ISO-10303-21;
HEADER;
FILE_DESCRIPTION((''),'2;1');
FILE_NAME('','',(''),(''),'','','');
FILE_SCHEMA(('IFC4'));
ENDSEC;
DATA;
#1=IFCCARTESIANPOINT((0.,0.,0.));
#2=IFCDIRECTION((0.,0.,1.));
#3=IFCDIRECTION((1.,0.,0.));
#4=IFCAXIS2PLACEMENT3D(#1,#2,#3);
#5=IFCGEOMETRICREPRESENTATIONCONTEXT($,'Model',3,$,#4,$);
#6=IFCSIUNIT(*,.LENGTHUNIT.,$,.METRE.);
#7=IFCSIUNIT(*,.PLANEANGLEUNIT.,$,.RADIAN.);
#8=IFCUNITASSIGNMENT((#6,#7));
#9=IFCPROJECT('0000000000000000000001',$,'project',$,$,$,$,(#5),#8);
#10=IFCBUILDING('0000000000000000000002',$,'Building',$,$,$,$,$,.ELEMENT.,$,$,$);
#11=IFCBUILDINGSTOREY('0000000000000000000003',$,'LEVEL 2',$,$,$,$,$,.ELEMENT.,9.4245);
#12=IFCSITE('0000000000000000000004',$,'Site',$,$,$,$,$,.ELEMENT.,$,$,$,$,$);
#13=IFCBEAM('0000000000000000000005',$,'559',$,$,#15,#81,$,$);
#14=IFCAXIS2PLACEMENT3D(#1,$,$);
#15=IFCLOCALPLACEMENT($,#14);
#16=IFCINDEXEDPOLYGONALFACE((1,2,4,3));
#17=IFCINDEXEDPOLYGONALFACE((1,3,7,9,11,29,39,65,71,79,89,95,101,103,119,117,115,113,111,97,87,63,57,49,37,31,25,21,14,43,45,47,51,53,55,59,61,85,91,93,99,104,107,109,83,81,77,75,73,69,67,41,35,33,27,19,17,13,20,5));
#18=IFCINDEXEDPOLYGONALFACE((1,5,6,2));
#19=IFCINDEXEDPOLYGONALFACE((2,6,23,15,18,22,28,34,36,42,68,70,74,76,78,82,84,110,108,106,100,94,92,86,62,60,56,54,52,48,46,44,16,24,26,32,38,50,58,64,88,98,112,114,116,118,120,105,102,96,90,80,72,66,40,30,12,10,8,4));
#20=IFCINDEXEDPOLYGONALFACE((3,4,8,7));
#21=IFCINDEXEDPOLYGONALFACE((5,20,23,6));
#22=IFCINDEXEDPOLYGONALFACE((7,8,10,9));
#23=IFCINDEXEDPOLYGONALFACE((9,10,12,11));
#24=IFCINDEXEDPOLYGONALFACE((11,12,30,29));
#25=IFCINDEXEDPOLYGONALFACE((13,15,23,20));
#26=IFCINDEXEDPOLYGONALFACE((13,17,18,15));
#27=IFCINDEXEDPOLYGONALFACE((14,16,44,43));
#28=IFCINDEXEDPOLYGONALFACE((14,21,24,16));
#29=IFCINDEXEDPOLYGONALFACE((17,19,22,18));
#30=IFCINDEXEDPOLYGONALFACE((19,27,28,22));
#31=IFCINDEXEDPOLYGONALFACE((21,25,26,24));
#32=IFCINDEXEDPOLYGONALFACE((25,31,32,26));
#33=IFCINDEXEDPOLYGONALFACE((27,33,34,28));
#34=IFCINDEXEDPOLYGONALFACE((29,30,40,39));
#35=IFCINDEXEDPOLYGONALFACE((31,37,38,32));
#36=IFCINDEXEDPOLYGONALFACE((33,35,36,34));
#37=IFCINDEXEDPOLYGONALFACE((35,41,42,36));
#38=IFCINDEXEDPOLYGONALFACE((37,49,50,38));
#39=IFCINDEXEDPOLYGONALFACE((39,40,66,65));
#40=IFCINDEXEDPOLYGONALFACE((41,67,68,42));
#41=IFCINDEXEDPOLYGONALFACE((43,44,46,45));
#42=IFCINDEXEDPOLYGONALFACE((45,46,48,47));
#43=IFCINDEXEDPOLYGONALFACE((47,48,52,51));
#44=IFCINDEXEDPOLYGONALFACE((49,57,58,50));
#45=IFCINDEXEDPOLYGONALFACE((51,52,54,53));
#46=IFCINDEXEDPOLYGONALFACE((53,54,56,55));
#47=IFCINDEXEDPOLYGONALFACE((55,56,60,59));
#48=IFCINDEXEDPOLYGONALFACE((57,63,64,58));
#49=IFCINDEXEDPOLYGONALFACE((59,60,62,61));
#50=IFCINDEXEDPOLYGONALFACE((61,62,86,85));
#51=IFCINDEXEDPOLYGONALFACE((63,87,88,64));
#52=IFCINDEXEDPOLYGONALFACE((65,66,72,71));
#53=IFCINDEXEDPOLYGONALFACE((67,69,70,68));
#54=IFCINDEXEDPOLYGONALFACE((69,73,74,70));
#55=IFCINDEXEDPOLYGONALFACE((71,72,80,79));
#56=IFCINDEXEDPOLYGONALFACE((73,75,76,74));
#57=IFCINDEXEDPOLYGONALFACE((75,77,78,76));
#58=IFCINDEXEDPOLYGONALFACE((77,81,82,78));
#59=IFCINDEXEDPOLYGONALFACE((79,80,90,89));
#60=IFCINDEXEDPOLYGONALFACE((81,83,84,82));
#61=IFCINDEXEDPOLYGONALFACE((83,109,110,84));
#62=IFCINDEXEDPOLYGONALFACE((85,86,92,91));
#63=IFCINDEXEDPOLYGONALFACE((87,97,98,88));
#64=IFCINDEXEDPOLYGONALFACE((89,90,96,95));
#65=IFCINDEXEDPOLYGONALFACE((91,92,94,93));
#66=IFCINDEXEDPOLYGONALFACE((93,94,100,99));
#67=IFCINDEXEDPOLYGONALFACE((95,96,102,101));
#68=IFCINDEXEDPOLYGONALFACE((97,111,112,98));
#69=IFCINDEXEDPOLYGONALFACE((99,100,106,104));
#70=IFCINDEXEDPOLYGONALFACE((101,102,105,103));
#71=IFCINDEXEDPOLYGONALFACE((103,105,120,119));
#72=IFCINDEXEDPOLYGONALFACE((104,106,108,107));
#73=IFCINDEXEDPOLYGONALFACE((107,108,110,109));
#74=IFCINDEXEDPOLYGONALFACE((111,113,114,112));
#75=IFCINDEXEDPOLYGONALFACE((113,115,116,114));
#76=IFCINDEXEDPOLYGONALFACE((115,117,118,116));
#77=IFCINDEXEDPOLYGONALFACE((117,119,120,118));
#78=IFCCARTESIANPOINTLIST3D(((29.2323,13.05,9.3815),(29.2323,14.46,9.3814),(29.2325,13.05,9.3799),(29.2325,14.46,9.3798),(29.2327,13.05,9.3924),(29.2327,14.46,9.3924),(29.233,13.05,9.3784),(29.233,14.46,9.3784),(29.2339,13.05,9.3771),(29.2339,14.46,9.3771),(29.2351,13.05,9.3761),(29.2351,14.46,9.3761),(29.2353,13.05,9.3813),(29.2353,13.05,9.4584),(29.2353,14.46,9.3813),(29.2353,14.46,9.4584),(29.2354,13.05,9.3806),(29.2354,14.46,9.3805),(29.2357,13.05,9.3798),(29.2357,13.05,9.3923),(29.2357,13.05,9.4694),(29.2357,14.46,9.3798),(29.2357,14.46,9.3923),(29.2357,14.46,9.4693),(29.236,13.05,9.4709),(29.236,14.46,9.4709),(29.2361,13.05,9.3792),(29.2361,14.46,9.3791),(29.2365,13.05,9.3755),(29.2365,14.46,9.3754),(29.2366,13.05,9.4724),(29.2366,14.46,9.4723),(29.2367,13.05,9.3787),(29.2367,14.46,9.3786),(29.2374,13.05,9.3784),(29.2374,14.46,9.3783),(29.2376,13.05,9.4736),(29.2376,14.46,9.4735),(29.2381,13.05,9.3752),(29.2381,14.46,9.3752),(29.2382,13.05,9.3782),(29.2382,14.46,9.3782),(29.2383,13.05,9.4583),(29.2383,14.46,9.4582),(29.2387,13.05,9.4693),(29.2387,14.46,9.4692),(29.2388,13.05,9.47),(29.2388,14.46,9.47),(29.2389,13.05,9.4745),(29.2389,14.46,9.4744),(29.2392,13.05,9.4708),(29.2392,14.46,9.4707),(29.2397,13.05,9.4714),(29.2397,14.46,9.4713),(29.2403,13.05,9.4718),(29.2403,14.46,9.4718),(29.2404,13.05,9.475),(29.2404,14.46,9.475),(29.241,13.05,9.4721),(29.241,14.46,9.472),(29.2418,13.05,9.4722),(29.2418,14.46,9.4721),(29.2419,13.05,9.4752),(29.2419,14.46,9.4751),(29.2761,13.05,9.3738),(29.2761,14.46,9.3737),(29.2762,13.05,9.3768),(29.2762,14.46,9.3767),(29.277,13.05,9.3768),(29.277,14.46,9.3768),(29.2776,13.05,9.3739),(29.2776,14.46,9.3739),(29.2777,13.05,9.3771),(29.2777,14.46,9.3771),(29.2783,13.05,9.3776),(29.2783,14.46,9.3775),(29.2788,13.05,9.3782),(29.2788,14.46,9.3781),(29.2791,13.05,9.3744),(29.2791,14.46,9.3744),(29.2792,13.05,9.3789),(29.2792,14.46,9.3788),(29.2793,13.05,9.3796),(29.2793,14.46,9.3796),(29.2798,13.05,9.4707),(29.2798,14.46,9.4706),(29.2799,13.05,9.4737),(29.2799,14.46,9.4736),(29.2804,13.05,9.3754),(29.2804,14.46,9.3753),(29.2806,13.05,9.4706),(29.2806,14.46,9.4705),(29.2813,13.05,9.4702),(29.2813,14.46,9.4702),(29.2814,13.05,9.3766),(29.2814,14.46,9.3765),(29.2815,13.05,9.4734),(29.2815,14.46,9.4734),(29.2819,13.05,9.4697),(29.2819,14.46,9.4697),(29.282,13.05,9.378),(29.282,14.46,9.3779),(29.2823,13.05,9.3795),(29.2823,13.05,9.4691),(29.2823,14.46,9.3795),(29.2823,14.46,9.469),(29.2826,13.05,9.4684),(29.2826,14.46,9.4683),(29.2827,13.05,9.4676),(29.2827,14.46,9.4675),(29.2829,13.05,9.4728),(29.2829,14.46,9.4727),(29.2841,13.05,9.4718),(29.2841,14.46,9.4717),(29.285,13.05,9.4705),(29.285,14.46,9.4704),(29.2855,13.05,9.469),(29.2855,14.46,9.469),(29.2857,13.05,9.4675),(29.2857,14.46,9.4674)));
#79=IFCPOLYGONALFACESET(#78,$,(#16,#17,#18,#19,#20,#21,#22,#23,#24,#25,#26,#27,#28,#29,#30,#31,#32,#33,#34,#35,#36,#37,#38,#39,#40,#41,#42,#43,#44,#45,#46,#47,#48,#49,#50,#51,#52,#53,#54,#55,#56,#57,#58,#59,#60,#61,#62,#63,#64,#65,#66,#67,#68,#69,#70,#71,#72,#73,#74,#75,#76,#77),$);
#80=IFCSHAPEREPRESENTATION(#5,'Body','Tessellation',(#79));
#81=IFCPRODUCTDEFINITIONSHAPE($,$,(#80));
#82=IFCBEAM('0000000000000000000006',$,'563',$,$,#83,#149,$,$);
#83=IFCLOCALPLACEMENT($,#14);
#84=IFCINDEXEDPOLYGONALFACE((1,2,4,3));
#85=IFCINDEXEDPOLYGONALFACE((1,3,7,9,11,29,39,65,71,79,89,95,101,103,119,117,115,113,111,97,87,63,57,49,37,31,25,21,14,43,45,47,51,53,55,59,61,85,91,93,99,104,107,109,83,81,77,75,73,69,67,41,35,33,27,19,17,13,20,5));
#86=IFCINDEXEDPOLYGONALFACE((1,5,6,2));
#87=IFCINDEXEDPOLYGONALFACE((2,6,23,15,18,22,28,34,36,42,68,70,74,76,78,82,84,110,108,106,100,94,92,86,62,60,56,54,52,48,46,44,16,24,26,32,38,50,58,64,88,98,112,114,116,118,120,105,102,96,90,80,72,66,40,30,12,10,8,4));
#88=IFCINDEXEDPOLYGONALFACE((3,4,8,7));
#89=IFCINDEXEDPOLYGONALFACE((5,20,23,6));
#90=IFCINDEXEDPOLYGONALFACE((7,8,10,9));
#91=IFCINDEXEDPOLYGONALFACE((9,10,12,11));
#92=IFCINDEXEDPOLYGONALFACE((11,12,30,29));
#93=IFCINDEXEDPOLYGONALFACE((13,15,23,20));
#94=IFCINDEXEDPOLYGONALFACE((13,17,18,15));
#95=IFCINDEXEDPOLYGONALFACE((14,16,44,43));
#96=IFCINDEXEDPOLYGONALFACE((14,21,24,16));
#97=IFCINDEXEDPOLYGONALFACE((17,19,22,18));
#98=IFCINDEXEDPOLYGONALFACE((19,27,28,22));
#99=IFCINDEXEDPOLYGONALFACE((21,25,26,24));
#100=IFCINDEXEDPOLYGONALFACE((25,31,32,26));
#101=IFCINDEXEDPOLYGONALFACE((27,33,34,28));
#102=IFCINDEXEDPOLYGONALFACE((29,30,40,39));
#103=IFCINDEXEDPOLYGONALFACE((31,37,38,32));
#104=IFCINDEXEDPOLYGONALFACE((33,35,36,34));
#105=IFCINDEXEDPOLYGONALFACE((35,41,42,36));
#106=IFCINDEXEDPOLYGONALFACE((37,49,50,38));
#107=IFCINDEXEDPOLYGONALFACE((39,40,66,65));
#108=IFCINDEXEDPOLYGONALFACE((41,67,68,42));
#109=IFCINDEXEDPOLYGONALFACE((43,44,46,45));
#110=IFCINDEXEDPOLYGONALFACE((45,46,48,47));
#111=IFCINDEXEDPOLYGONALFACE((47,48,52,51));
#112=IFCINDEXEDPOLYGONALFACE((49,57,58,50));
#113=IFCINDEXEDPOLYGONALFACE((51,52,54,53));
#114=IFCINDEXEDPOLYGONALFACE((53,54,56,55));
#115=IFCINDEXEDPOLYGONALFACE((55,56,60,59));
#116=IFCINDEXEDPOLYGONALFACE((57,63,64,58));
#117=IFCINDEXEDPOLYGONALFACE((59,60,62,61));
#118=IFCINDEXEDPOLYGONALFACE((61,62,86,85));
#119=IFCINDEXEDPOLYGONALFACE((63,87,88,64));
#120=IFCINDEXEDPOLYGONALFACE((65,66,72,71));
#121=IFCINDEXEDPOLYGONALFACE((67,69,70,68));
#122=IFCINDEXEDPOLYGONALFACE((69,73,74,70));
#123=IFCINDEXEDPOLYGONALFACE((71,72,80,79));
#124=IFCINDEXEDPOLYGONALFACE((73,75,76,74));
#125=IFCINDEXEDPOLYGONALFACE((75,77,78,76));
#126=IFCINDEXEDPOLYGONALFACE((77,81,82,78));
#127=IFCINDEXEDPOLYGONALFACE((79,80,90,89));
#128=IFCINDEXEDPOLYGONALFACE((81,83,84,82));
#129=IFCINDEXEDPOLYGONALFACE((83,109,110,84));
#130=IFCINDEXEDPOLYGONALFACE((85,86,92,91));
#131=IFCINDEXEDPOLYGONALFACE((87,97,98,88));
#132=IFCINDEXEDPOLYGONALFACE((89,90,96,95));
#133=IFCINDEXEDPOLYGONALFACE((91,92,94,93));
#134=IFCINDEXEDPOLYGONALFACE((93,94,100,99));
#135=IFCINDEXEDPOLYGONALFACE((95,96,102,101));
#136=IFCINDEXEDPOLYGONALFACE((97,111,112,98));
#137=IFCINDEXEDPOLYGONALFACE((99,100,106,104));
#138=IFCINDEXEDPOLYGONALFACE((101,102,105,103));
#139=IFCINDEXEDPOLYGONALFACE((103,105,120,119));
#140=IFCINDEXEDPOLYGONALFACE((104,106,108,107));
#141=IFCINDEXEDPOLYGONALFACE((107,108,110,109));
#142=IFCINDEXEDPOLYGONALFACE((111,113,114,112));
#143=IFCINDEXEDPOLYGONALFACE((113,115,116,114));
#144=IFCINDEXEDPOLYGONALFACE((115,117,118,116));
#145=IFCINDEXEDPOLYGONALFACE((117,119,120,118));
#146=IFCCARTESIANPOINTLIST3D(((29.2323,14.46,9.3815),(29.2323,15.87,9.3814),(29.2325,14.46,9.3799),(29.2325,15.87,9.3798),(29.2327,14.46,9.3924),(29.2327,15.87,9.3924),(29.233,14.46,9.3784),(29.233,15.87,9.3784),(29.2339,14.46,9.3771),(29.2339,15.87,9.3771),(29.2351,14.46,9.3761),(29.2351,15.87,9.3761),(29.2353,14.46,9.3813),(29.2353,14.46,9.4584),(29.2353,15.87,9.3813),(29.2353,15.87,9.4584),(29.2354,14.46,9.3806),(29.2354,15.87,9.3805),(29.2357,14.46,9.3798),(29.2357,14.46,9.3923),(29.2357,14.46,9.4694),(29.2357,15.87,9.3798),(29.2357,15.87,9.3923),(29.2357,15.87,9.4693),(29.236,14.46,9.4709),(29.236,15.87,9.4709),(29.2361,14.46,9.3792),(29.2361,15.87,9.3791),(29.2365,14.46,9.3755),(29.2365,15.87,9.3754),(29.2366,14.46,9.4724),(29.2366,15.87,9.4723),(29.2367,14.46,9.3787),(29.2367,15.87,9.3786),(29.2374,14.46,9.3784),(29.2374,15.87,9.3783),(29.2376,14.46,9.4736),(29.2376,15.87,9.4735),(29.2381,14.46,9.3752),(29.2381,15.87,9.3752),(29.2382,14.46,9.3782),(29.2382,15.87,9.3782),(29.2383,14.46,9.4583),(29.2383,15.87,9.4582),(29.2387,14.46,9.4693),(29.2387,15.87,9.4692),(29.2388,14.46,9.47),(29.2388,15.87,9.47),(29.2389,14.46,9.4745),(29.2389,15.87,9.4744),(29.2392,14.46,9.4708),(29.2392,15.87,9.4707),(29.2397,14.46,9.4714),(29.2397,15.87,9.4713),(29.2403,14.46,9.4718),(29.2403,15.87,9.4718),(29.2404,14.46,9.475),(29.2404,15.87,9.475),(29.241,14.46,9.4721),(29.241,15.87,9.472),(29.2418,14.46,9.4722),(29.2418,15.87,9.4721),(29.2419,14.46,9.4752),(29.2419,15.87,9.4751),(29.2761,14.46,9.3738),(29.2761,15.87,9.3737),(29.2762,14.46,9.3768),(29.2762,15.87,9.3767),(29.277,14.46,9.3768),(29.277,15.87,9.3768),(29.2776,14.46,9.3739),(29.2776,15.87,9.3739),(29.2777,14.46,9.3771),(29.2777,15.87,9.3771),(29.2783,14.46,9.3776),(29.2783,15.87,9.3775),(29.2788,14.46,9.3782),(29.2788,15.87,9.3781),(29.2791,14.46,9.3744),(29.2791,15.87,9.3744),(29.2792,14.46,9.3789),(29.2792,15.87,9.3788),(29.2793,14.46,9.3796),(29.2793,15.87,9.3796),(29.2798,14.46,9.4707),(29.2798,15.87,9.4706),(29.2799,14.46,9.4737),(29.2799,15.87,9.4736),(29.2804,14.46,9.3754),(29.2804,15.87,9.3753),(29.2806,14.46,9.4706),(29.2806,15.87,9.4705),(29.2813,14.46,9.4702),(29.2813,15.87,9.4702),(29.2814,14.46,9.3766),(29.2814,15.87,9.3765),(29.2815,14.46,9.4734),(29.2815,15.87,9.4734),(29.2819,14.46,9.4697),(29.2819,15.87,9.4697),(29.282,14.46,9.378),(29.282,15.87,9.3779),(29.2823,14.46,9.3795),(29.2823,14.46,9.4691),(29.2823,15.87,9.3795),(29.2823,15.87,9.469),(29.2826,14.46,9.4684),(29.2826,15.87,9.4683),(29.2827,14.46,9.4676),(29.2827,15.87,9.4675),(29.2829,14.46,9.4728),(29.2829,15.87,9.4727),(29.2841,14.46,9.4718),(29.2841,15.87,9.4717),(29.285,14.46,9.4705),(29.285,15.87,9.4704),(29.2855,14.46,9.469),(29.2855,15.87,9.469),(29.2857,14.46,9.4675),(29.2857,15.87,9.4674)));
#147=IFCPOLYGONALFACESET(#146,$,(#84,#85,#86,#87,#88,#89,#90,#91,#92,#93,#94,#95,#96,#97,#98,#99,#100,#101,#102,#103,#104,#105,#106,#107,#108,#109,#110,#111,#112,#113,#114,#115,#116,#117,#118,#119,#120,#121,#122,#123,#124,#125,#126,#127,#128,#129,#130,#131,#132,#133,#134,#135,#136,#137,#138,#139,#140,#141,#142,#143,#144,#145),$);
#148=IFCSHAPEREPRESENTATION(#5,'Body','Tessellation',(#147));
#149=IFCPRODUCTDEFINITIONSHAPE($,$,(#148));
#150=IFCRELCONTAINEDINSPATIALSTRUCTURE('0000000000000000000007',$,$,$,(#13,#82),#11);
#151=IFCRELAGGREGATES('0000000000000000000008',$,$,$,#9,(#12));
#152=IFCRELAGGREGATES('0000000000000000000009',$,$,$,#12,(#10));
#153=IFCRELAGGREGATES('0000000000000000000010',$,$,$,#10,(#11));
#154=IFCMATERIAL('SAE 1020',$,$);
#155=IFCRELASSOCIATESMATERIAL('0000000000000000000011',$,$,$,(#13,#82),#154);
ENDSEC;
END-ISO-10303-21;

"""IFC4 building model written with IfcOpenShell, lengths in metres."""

from ifc_helpers import new_model, si_unit, frame, origin_with_axes, origin_2d_with_axis, place, context, project, spatial, c_section, extrude, material, material_profile, profile_set, profile_usage, element, save


model = new_model("IFC4")

# Units and contexts
model_context = context("Model", 3, world=origin_with_axes())
ifc_project = project(units=[si_unit("LENGTHUNIT", "METRE"), si_unit("PLANEANGLEUNIT", "RADIAN")], contexts=[model_context])

# Site, building, storey
site = spatial("IfcSite", under=ifc_project, Name="Site", CompositionType="ELEMENT")
building = spatial("IfcBuilding", under=site, Name="Building", CompositionType="ELEMENT")
storey = spatial("IfcBuildingStorey", under=building, Name="LEVEL 2", CompositionType="ELEMENT", Elevation=9.4245)

# Beams
ifc_material = material(Name="SAE 1020")
ifc_material_profile_1 = material_profile(ifc_material, c_section(Depth=0.1, Width=0.05, WallThickness=0.003, Girth=0.017, InternalFilletRadius=0.003, at=origin_2d_with_axis()))
ifc_profile_set_1 = profile_set([ifc_material_profile_1])
ifc_profile_usage_1 = profile_usage(ifc_profile_set_1, cardinal=10)
beam_1_placement = place(None, frame((29.259, 13.05, 9.4245), z_axis=(0.0, 1.0, -0.00003), x_axis=(-0.999256, 0.000001, 0.038562)))
element("IfcBeam", 1, at=beam_1_placement, inside=storey, material=ifc_profile_usage_1, Name="559", context=model_context, shape_type="SweptSolid", body=[
    extrude(c_section(Depth=0.1, Width=0.05, WallThickness=0.003, Girth=0.017, InternalFilletRadius=0.003, at=origin_2d_with_axis()), origin_with_axes(), (0.0, 0.0, 1.0), 1.41),
])
ifc_material_profile_2 = material_profile(ifc_material, c_section(Depth=0.1, Width=0.05, WallThickness=0.003, Girth=0.017, InternalFilletRadius=0.003, at=origin_2d_with_axis()))
ifc_profile_set_2 = profile_set([ifc_material_profile_2])
ifc_profile_usage_2 = profile_usage(ifc_profile_set_2, cardinal=10)
beam_2_placement = place(None, frame((29.259, 14.46, 9.4245), z_axis=(0.0, 1.0, -0.00003), x_axis=(-0.999256, 0.000001, 0.038562)))
element("IfcBeam", 2, at=beam_2_placement, inside=storey, material=ifc_profile_usage_2, Name="563", context=model_context, shape_type="SweptSolid", body=[
    extrude(c_section(Depth=0.1, Width=0.05, WallThickness=0.003, Girth=0.017, InternalFilletRadius=0.003, at=origin_2d_with_axis()), origin_with_axes(), (0.0, 0.0, 1.0), 1.41),
])

save(model, "model.ifc")
